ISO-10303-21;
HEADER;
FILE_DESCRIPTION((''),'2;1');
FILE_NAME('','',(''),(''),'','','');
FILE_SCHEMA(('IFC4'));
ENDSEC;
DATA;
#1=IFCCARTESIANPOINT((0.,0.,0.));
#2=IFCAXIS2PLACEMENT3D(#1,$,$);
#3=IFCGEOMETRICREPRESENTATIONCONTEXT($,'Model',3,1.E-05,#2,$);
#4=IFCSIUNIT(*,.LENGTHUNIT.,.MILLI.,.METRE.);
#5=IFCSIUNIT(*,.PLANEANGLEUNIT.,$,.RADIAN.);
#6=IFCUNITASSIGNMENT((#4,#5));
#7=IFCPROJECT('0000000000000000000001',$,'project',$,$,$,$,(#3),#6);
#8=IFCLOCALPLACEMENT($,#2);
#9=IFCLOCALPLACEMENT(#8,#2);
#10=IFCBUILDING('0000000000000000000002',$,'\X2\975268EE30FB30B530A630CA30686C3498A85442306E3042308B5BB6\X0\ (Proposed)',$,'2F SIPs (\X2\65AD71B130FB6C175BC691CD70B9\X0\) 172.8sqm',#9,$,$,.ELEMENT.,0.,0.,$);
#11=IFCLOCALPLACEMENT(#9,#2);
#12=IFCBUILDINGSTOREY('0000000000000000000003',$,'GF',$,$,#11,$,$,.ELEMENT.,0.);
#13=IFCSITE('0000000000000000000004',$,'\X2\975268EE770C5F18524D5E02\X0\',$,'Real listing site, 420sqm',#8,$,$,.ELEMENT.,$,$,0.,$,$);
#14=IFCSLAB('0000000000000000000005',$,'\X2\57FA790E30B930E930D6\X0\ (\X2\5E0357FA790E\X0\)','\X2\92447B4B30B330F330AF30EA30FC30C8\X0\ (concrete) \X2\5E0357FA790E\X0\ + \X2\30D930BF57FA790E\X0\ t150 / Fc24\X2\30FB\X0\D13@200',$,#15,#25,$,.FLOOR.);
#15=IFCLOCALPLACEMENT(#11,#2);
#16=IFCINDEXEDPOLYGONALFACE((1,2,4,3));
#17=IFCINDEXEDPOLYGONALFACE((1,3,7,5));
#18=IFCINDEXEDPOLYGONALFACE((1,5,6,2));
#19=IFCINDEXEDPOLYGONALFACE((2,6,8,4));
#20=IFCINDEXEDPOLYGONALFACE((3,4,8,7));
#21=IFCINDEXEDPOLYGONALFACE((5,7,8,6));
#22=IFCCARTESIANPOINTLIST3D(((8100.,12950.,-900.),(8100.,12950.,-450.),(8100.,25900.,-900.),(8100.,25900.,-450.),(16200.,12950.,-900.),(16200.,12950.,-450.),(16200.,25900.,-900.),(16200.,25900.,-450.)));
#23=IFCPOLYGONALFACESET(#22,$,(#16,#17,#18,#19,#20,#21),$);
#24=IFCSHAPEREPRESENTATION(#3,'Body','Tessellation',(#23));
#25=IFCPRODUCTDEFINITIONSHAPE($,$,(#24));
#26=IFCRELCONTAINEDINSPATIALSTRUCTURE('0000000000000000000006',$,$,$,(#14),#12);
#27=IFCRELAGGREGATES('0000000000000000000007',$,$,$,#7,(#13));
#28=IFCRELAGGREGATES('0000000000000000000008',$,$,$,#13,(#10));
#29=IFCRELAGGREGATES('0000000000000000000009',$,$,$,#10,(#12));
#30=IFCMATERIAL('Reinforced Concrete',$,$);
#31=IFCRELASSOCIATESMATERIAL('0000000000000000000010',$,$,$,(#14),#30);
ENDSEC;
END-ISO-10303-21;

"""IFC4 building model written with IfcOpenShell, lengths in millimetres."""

from ifc_helpers import new_model, si_unit, frame, frame_2d, origin, place, context, project, spatial, rectangle, extrude, material, element, save


model = new_model("IFC4")

# Units and contexts
model_context = context("Model", 3, precision=1e-05, world=origin())
ifc_project = project(units=[si_unit("LENGTHUNIT", "METRE", prefix="MILLI"), si_unit("PLANEANGLEUNIT", "RADIAN")], contexts=[model_context])

# Site, building, storey
site_placement = place(None, origin())
site = spatial("IfcSite", under=ifc_project, at=site_placement, Name="青森県弘前市", ObjectType="Real listing site, 420sqm", CompositionType="ELEMENT", RefElevation=0.0)
building_placement = place(site_placement, origin())
building = spatial("IfcBuilding", under=site, at=building_placement, Name="青森・サウナと水風呂のある家 (Proposed)", ObjectType="2F SIPs (断熱・気密重点) 172.8sqm", CompositionType="ELEMENT", ElevationOfRefHeight=0.0, ElevationOfTerrain=0.0)
storey_placement = place(building_placement, origin())
storey = spatial("IfcBuildingStorey", under=building, at=storey_placement, Name="GF", CompositionType="ELEMENT", Elevation=0.0)

# Slab
ifc_material_1 = material(Name="Reinforced Concrete")
slab_1_placement = place(storey_placement, frame((4050.0, 6475.0, -450.0)))
element("IfcSlab", 1, at=slab_1_placement, inside=storey, material=ifc_material_1, Name="基礎スラブ (布基礎)", Description="鉄筋コンクリート (concrete) 布基礎 + ベタ基礎 t150 / Fc24・D13@200", PredefinedType="FLOOR", context=model_context, shape_type="SweptSolid", body=[
    extrude(rectangle(XDim=8100.0, YDim=12950.0, at=frame_2d((4050.0, 6475.0))), frame((4050.0, 6475.0, -450.0)), (0.0, 0.0, 1.0), 450.0),
])

save(model, "model.ifc")
